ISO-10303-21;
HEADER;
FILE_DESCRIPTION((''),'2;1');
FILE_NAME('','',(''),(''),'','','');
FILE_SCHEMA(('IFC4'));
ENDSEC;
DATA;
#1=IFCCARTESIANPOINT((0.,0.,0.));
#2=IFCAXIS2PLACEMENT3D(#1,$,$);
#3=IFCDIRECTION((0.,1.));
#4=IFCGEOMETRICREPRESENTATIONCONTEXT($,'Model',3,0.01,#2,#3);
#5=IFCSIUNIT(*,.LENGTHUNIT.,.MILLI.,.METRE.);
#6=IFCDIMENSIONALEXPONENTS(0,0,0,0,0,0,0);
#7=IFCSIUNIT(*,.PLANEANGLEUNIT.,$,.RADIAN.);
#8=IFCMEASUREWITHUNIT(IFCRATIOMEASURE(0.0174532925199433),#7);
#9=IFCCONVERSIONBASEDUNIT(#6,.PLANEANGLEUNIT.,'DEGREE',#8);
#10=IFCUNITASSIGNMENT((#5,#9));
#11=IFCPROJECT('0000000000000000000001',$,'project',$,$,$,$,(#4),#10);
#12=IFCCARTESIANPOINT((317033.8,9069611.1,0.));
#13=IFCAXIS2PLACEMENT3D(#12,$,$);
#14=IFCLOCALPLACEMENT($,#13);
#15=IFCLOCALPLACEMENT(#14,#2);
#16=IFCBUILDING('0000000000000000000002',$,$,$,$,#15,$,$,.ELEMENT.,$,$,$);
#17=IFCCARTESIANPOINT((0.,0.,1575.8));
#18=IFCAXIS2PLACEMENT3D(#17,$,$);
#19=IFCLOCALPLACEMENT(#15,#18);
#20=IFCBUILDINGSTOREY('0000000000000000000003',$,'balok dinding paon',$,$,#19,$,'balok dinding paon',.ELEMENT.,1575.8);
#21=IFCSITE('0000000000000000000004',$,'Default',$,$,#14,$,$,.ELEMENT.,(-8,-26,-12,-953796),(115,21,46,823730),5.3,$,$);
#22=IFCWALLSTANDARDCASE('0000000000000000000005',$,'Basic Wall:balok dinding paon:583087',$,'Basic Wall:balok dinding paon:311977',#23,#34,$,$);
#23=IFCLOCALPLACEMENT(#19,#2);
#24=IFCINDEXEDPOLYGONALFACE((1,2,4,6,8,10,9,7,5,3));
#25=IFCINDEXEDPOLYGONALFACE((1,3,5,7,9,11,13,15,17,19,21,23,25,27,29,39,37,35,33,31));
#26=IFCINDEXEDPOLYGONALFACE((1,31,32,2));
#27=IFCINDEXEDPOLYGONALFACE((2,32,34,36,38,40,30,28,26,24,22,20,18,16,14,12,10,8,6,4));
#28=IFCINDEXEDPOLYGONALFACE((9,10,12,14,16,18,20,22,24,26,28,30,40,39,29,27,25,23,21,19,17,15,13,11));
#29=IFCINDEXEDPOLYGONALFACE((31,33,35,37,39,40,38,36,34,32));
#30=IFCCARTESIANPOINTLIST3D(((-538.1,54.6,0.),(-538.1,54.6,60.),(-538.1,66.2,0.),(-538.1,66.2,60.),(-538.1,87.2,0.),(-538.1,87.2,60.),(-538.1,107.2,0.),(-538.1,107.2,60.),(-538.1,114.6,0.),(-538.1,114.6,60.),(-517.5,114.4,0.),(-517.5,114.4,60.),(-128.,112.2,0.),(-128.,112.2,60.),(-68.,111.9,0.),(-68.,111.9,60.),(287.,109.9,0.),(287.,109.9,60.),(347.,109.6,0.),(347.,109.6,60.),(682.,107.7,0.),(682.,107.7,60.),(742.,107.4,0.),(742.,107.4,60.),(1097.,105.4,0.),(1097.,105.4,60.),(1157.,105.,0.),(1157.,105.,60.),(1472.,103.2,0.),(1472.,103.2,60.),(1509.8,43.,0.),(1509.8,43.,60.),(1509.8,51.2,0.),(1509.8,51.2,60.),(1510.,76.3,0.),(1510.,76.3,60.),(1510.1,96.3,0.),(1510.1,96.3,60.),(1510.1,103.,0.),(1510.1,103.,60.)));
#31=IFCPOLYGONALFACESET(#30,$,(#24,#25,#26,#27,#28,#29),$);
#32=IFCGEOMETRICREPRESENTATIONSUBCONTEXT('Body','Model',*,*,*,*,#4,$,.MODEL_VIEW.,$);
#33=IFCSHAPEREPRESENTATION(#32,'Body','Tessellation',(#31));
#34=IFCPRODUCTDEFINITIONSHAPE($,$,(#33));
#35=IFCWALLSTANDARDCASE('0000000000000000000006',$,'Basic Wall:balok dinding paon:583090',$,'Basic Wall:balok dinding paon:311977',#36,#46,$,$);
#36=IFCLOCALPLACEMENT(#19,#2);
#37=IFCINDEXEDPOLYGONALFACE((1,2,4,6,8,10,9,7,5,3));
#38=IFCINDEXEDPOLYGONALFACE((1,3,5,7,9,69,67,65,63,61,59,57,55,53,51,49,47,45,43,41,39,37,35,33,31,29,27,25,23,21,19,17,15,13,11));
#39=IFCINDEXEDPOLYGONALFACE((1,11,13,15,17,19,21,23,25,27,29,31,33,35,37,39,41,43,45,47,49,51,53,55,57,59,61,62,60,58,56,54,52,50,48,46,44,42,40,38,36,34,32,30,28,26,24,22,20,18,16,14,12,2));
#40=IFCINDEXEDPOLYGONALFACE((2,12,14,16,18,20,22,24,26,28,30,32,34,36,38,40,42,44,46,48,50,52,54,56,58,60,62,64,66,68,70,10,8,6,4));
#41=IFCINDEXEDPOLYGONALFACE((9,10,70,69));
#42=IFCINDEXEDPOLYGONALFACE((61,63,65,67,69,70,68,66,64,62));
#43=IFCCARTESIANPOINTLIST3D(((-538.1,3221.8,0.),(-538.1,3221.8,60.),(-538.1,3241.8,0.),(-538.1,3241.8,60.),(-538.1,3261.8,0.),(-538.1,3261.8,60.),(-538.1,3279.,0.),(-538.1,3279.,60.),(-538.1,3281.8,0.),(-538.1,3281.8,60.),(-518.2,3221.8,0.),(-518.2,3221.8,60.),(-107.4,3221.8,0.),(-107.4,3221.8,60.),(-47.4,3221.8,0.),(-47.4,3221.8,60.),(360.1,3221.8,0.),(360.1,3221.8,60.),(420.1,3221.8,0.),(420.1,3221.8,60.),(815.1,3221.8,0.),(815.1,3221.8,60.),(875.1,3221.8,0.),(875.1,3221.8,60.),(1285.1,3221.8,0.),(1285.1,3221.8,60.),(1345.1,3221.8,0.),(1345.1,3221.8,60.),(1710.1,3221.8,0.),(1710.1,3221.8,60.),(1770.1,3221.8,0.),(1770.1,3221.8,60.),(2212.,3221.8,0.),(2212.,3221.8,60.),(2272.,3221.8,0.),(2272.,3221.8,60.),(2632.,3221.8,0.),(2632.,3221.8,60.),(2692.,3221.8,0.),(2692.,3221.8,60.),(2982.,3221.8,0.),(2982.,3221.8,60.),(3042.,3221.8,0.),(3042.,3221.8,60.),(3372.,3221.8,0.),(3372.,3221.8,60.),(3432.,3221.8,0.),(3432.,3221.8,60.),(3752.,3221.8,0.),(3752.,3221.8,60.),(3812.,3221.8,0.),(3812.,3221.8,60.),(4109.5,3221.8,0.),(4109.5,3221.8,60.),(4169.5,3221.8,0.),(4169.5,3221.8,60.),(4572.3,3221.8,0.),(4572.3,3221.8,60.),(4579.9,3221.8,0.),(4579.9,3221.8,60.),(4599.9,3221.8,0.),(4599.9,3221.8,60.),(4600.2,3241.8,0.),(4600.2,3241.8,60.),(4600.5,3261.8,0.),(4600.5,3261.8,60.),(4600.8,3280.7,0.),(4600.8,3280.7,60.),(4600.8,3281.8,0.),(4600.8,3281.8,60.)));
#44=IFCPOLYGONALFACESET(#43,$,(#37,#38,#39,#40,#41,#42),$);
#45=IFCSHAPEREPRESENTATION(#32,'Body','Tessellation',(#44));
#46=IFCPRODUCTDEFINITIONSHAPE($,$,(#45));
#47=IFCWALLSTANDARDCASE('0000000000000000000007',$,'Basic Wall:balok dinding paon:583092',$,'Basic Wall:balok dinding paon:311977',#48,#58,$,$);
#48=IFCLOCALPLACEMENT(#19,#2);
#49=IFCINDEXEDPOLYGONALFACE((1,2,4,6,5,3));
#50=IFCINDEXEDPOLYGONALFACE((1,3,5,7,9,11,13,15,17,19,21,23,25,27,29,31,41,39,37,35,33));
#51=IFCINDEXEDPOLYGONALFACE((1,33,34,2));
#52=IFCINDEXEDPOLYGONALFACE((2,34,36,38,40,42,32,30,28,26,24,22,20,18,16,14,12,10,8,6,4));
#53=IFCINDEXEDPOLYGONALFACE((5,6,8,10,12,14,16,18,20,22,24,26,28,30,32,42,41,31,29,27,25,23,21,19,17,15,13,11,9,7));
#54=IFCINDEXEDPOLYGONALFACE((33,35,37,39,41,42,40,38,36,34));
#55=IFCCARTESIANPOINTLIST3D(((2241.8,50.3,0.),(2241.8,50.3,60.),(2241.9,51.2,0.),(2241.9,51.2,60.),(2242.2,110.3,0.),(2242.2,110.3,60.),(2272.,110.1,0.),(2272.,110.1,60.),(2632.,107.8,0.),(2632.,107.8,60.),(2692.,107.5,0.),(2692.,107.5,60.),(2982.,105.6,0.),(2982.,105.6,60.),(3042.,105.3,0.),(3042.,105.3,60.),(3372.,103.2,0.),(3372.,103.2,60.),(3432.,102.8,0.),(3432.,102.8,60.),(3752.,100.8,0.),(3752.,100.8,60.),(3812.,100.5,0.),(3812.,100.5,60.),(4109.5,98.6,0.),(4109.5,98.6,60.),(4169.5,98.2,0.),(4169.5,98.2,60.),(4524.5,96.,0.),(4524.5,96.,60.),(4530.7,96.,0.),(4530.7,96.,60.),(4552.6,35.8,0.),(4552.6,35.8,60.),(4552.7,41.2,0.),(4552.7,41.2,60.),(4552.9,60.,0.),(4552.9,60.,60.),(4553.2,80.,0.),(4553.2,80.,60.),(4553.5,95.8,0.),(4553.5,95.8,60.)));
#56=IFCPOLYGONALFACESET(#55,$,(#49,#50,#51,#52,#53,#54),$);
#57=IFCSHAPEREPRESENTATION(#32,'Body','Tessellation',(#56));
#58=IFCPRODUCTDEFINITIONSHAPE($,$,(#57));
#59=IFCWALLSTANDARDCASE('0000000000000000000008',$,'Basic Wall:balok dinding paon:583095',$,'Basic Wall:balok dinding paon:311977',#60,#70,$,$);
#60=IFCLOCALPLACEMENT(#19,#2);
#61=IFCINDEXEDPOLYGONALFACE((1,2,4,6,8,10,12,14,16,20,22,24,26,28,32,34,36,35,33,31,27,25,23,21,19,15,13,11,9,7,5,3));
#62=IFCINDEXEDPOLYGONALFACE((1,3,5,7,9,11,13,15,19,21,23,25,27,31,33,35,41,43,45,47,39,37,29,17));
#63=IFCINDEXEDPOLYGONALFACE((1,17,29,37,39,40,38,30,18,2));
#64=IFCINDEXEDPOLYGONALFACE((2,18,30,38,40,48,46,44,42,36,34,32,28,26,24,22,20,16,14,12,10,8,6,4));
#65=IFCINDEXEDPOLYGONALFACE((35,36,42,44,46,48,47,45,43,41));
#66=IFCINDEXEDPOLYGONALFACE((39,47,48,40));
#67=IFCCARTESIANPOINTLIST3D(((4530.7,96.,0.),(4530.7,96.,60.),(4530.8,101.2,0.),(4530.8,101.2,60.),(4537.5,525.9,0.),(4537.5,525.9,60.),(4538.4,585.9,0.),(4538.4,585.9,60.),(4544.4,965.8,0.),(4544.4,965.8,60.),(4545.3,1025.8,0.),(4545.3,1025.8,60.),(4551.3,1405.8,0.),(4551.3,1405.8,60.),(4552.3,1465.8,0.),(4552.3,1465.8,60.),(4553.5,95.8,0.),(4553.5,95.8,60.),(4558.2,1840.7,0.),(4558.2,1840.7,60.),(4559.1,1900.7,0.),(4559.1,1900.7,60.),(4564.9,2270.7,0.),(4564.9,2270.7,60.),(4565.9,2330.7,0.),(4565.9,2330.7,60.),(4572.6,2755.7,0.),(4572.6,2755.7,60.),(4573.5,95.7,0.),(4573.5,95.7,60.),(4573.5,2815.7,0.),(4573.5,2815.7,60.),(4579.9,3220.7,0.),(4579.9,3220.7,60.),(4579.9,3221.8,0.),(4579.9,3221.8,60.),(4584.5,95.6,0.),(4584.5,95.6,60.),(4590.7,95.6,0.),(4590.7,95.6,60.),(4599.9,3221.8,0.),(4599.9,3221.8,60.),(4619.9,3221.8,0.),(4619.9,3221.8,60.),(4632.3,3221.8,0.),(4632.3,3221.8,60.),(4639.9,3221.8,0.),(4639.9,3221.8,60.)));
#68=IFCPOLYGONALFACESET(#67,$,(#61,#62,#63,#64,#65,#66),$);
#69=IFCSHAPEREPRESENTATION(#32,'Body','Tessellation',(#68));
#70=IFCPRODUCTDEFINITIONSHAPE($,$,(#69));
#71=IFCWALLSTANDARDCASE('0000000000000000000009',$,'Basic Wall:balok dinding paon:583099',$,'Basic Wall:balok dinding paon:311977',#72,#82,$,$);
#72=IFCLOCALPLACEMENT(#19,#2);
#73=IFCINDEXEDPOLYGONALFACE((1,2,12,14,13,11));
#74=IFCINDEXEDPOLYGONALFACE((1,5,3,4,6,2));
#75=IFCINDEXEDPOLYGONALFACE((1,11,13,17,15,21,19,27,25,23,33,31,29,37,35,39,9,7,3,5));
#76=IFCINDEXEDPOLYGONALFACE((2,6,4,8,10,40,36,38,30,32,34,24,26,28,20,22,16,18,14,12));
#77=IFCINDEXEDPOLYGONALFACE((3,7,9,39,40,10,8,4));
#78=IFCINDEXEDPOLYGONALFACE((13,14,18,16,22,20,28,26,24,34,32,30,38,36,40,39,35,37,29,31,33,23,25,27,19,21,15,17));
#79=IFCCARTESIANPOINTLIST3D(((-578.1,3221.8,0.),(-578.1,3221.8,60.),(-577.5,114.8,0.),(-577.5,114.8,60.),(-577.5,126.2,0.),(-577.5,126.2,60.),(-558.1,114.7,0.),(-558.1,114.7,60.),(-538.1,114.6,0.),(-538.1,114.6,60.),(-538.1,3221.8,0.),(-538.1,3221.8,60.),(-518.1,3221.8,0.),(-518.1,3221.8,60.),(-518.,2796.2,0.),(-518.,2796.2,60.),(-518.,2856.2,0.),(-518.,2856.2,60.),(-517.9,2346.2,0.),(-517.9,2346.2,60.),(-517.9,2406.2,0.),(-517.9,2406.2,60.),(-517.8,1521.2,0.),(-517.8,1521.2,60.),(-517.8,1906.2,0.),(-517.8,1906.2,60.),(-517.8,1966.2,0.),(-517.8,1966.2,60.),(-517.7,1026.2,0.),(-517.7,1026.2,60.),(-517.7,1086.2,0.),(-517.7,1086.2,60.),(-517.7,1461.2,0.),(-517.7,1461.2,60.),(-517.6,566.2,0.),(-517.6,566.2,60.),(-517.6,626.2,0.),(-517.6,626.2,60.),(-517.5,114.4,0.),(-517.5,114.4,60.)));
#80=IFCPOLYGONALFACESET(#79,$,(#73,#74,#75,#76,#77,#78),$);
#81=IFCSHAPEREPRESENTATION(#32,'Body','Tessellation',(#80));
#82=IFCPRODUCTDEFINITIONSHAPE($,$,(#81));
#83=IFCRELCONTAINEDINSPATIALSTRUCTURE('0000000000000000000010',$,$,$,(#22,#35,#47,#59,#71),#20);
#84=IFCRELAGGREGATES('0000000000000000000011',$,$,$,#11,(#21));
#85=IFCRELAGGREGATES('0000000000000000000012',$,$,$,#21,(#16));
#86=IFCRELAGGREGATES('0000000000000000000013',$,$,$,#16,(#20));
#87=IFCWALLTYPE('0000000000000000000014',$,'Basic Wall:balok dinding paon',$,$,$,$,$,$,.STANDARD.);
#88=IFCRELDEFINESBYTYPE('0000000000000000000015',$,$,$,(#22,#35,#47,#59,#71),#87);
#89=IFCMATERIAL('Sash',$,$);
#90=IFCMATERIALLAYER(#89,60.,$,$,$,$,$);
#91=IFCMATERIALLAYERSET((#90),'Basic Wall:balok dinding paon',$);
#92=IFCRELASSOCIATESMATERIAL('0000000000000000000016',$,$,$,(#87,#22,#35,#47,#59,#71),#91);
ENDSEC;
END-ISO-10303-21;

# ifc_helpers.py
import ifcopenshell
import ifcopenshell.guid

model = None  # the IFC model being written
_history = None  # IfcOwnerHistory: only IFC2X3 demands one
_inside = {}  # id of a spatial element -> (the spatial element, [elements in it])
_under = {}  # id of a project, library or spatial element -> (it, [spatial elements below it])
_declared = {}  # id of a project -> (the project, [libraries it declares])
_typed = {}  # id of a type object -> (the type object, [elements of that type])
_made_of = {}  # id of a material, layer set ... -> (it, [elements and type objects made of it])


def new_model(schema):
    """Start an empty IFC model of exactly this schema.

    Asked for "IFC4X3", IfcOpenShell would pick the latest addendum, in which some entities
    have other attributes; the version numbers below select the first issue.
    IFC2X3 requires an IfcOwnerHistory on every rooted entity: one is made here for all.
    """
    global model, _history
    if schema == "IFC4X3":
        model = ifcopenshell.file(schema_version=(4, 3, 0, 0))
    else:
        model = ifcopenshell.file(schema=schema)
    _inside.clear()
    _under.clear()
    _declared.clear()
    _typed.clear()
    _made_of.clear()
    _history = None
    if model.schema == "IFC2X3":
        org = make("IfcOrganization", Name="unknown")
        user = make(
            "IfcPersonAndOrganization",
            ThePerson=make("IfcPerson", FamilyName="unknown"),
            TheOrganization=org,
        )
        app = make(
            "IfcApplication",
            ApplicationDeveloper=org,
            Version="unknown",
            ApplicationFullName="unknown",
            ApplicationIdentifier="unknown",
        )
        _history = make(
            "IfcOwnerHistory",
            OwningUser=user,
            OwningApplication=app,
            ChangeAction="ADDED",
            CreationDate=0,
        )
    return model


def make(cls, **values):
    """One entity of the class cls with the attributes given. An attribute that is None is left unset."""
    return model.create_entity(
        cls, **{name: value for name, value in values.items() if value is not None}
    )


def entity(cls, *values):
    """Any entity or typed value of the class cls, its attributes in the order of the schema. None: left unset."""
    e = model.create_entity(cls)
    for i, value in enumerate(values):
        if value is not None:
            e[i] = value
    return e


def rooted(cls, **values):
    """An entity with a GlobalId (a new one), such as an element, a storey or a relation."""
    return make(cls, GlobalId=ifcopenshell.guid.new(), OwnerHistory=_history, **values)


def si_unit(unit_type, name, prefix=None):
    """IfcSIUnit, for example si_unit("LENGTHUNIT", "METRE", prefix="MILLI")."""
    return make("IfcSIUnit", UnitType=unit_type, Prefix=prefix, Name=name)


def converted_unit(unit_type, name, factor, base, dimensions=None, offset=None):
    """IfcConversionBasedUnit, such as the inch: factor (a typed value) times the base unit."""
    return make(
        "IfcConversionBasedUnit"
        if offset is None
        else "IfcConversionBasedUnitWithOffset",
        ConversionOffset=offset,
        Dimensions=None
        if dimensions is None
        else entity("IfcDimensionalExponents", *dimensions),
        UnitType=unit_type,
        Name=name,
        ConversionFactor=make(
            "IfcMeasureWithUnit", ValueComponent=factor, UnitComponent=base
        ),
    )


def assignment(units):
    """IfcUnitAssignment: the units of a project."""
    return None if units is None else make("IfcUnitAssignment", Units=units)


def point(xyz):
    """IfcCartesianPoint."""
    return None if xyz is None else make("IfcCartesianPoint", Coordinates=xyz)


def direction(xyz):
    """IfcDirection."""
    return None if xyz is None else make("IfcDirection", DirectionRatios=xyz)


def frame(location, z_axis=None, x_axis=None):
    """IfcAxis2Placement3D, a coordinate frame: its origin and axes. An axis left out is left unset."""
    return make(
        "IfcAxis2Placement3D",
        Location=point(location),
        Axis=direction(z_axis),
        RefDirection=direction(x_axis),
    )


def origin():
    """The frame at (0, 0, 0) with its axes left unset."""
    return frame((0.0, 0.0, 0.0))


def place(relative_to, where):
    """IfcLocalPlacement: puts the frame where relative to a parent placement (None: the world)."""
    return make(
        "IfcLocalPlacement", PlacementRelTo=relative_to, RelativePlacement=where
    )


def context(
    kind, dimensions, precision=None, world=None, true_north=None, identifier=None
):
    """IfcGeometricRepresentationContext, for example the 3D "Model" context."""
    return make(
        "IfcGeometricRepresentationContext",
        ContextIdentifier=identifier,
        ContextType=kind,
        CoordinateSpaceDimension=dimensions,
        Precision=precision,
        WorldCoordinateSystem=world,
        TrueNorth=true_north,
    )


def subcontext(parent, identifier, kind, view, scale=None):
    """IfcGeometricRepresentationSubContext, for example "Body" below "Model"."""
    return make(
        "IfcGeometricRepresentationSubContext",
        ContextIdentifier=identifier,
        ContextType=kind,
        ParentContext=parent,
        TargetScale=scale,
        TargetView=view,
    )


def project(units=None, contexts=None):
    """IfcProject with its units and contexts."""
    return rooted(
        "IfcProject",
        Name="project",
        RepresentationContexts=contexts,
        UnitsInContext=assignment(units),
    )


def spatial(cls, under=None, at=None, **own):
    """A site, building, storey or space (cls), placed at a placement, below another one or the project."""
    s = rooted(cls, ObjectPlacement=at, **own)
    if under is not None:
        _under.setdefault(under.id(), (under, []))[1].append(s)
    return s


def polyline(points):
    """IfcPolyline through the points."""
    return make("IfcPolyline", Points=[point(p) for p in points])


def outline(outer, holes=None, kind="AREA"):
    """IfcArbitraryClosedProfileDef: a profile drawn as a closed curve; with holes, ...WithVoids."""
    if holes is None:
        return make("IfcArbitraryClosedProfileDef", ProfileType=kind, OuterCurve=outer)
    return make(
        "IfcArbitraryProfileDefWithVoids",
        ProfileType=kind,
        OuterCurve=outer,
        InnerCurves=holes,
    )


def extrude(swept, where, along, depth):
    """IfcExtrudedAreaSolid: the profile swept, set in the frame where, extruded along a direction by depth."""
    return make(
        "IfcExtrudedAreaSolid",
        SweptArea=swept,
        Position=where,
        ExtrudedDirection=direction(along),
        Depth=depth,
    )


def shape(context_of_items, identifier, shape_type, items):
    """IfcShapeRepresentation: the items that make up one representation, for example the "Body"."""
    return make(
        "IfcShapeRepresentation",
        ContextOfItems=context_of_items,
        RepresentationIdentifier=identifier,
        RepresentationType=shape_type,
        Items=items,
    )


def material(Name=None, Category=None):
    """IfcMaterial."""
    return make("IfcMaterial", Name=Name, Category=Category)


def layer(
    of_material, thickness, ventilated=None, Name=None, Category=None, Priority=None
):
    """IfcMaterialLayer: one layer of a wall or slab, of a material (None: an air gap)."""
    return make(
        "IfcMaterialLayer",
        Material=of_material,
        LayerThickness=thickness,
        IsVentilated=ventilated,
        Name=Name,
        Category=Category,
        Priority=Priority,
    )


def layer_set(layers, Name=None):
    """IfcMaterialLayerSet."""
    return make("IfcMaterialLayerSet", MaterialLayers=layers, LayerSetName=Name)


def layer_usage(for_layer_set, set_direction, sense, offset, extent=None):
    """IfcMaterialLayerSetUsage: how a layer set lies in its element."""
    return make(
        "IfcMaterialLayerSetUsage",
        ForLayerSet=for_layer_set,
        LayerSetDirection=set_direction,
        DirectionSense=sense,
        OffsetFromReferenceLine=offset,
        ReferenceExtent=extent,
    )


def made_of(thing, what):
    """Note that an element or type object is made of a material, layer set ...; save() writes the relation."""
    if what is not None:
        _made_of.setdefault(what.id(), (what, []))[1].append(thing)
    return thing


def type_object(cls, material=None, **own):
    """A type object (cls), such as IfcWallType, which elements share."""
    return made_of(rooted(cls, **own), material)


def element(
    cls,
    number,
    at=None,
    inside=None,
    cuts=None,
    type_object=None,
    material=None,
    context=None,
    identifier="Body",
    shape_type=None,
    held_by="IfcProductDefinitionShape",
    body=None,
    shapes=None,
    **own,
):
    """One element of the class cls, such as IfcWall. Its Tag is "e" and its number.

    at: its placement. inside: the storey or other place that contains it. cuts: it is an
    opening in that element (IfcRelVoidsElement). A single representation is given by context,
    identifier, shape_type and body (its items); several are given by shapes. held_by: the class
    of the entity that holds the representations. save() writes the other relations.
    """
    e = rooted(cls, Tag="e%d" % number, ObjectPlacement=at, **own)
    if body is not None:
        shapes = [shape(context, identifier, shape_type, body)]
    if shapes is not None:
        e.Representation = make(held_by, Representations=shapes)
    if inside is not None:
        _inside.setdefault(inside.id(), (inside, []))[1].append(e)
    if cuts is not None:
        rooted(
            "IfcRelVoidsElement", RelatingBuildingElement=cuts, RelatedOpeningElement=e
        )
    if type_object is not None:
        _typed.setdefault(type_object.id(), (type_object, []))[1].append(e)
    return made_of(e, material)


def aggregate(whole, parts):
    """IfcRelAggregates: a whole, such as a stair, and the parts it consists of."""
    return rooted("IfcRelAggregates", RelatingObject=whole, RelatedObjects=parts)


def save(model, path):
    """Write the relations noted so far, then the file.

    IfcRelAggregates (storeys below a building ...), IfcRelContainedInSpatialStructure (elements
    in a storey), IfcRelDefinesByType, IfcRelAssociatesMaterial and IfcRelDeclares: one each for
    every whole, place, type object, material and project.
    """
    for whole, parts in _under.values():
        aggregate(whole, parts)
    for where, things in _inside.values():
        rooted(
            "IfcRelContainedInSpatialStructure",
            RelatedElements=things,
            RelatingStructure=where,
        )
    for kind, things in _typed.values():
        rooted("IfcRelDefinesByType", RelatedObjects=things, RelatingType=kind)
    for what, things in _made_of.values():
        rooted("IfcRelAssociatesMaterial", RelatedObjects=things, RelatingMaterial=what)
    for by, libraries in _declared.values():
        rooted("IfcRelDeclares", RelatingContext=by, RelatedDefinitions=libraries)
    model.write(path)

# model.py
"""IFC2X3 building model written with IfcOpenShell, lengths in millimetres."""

from ifc_helpers import new_model, entity, si_unit, converted_unit, direction, frame, origin, place, context, subcontext, project, spatial, polyline, outline, extrude, material, layer, layer_set, layer_usage, type_object, element, save


model = new_model("IFC2X3")

# Units and contexts
model_context = context("Model", 3, precision=0.01, world=origin(), true_north=direction((0.0, 1.0)))
body_context = subcontext(model_context, "Body", "Model", "MODEL_VIEW")
ifc_project = project(units=[si_unit("LENGTHUNIT", "METRE", prefix="MILLI"), converted_unit("PLANEANGLEUNIT", "DEGREE", entity("IfcRatioMeasure", 0.0174532925199433), si_unit("PLANEANGLEUNIT", "RADIAN"), dimensions=[0, 0, 0, 0, 0, 0, 0])], contexts=[model_context])

# Site, building, storey
site_placement = place(None, frame((317033.8, 9069611.1, 0.0)))
site = spatial("IfcSite", under=ifc_project, at=site_placement, Name="Default", CompositionType="ELEMENT", RefLatitude=(-8, -26, -12, -953796), RefLongitude=(115, 21, 46, 823730), RefElevation=5.3)
building_placement = place(site_placement, origin())
building = spatial("IfcBuilding", under=site, at=building_placement, CompositionType="ELEMENT")
storey_placement = place(building_placement, frame((0.0, 0.0, 1575.8)))
storey = spatial("IfcBuildingStorey", under=building, at=storey_placement, Name="balok dinding paon", LongName="balok dinding paon", CompositionType="ELEMENT", Elevation=1575.8)

# Shared definitions
ifc_material_1 = material(Name="Sash")

# Walls
ifc_layer = layer(ifc_material_1, 60.0)
ifc_layer_set = layer_set([ifc_layer], Name="Basic Wall:balok dinding paon")
ifc_layer_usage_1 = layer_usage(ifc_layer_set, "AXIS2", "NEGATIVE", 30.0)
wall_type = type_object("IfcWallType", Name="Basic Wall:balok dinding paon", PredefinedType="STANDARD", material=ifc_layer_set)
wall_1_placement = place(storey_placement, frame((-538.3, 84.6, 0.0), z_axis=(0.0, 0.0, 1.0), x_axis=(0.999984, -0.005623, 0.0)))
element("IfcWallStandardCase", 1, at=wall_1_placement, inside=storey, type_object=wall_type, material=ifc_layer_usage_1, Name="Basic Wall:balok dinding paon:583087", ObjectType="Basic Wall:balok dinding paon:311977", context=body_context, shape_type="SweptSolid", body=[
    extrude(outline(polyline([(2048.2, -30.0), (2048.2, -21.9), (2048.2, 3.2), (2048.2, 23.2), (2048.2, 30.0), (2010.2, 30.0), (1695.2, 30.0), (1635.1, 30.0), (1280.1, 30.0), (1220.1, 30.0), (885.1, 30.0), (825.1, 30.0), (470.1, 30.0), (410.1, 30.0), (20.6, 30.0), (0.0, 30.0), (0.0, 22.7), (0.2, 2.7), (0.3, -18.4), (0.3, -30.0), (2048.2, -30.0)])), origin(), (0.0, 0.0, 1.0), 60.0),
])
ifc_layer_usage_2 = layer_usage(ifc_layer_set, "AXIS2", "NEGATIVE", 30.0)
wall_2_placement = place(storey_placement, frame((-538.1, 3251.8, 0.0)))
element("IfcWallStandardCase", 2, at=wall_2_placement, inside=storey, type_object=wall_type, material=ifc_layer_usage_2, Name="Basic Wall:balok dinding paon:583090", ObjectType="Basic Wall:balok dinding paon:311977", context=body_context, shape_type="SweptSolid", body=[
    extrude(outline(polyline([(5138.0, -30.0), (5138.3, -10.0), (5138.6, 10.0), (5138.9, 28.9), (5138.9, 30.0), (0.0, 30.0), (0.0, 27.2), (0.0, 10.0), (0.0, -10.0), (0.0, -30.0), (19.9, -30.0), (430.7, -30.0), (490.7, -30.0), (898.2, -30.0), (958.2, -30.0), (1353.2, -30.0), (1413.2, -30.0), (1823.2, -30.0), (1883.2, -30.0), (2248.2, -30.0), (2308.2, -30.0), (2750.1, -30.0), (2810.1, -30.0), (3170.1, -30.0), (3230.1, -30.0), (3520.1, -30.0), (3580.1, -30.0), (3910.1, -30.0), (3970.1, -30.0), (4290.1, -30.0), (4350.1, -30.0), (4647.6, -30.0), (4707.6, -30.0), (5110.4, -30.0), (5118.0, -30.0), (5138.0, -30.0)])), origin(), (0.0, 0.0, 1.0), 60.0),
])
ifc_layer_usage_3 = layer_usage(ifc_layer_set, "AXIS2", "NEGATIVE", 30.0)
wall_3_placement = place(storey_placement, frame((2242.0, 80.3, 0.0), z_axis=(0.0, 0.0, 1.0), x_axis=(0.99998, -0.006246, 0.0)))
element("IfcWallStandardCase", 3, at=wall_3_placement, inside=storey, type_object=wall_type, material=ifc_layer_usage_3, Name="Basic Wall:balok dinding paon:583092", ObjectType="Basic Wall:balok dinding paon:311977", context=body_context, shape_type="SweptSolid", body=[
    extrude(outline(polyline([(2310.8, -30.0), (2310.8, -24.7), (2311.0, -5.9), (2311.2, 14.1), (2311.3, 30.0), (2288.5, 30.0), (2282.4, 30.0), (1927.4, 30.0), (1867.3, 30.0), (1569.8, 30.0), (1509.8, 30.0), (1189.8, 30.0), (1129.8, 30.0), (799.8, 30.0), (739.8, 30.0), (449.8, 30.0), (389.8, 30.0), (29.8, 30.0), (0.0, 30.0), (0.0, -29.1), (0.0, -30.0), (2310.8, -30.0)])), origin(), (0.0, 0.0, 1.0), 60.0),
])
ifc_layer_usage_4 = layer_usage(ifc_layer_set, "AXIS2", "NEGATIVE", 30.0)
wall_4_placement = place(storey_placement, frame((4609.9, 3222.3, 0.0), z_axis=(0.0, 0.0, 1.0), x_axis=(-0.015744, -0.999876, 0.0)))
element("IfcWallStandardCase", 4, at=wall_4_placement, inside=storey, type_object=wall_type, material=ifc_layer_usage_4, Name="Basic Wall:balok dinding paon:583095", ObjectType="Basic Wall:balok dinding paon:311977", context=body_context, shape_type="SweptSolid", body=[
    extrude(outline(polyline([(3127.2, -30.0), (3127.0, -7.2), (3126.8, 12.8), (3126.7, 23.8), (3126.6, 30.0), (0.0, 30.0), (0.1, 22.4), (0.3, 10.0), (0.6, -10.0), (0.9, -30.0), (2.0, -30.0), (407.1, -30.0), (467.1, -30.0), (892.1, -30.0), (952.1, -30.0), (1322.2, -30.0), (1382.2, -30.0), (1757.1, -30.0), (1817.2, -30.0), (2197.2, -30.0), (2257.2, -30.0), (2637.2, -30.0), (2697.2, -30.0), (3122.0, -30.0), (3127.2, -30.0)])), origin(), (0.0, 0.0, 1.0), 60.0),
])
ifc_layer_usage_5 = layer_usage(ifc_layer_set, "AXIS2", "NEGATIVE", 30.0)
wall_5_placement = place(storey_placement, frame((-548.1, 3221.8, 0.0), z_axis=(0.0, 0.0, 1.0), x_axis=(0.000189, -1.0, 0.0)))
element("IfcWallStandardCase", 5, at=wall_5_placement, inside=storey, type_object=wall_type, material=ifc_layer_usage_5, Name="Basic Wall:balok dinding paon:583099", ObjectType="Basic Wall:balok dinding paon:311977", context=body_context, shape_type="SweptSolid", body=[
    extrude(outline(polyline([(3107.0, -30.0), (3107.1, -10.6), (3107.3, 9.4), (3107.4, 30.0), (2655.6, 30.0), (2595.6, 30.0), (2195.6, 30.0), (2135.6, 30.0), (1760.6, 30.0), (1700.6, 30.0), (1315.6, 30.0), (1255.6, 30.0), (875.6, 30.0), (815.6, 30.0), (425.6, 30.0), (365.6, 30.0), (0.0, 30.0), (0.0, 10.0), (0.0, -30.0), (3095.6, -30.0), (3107.0, -30.0)])), origin(), (0.0, 0.0, 1.0), 60.0),
])

save(model, "model.ifc")
